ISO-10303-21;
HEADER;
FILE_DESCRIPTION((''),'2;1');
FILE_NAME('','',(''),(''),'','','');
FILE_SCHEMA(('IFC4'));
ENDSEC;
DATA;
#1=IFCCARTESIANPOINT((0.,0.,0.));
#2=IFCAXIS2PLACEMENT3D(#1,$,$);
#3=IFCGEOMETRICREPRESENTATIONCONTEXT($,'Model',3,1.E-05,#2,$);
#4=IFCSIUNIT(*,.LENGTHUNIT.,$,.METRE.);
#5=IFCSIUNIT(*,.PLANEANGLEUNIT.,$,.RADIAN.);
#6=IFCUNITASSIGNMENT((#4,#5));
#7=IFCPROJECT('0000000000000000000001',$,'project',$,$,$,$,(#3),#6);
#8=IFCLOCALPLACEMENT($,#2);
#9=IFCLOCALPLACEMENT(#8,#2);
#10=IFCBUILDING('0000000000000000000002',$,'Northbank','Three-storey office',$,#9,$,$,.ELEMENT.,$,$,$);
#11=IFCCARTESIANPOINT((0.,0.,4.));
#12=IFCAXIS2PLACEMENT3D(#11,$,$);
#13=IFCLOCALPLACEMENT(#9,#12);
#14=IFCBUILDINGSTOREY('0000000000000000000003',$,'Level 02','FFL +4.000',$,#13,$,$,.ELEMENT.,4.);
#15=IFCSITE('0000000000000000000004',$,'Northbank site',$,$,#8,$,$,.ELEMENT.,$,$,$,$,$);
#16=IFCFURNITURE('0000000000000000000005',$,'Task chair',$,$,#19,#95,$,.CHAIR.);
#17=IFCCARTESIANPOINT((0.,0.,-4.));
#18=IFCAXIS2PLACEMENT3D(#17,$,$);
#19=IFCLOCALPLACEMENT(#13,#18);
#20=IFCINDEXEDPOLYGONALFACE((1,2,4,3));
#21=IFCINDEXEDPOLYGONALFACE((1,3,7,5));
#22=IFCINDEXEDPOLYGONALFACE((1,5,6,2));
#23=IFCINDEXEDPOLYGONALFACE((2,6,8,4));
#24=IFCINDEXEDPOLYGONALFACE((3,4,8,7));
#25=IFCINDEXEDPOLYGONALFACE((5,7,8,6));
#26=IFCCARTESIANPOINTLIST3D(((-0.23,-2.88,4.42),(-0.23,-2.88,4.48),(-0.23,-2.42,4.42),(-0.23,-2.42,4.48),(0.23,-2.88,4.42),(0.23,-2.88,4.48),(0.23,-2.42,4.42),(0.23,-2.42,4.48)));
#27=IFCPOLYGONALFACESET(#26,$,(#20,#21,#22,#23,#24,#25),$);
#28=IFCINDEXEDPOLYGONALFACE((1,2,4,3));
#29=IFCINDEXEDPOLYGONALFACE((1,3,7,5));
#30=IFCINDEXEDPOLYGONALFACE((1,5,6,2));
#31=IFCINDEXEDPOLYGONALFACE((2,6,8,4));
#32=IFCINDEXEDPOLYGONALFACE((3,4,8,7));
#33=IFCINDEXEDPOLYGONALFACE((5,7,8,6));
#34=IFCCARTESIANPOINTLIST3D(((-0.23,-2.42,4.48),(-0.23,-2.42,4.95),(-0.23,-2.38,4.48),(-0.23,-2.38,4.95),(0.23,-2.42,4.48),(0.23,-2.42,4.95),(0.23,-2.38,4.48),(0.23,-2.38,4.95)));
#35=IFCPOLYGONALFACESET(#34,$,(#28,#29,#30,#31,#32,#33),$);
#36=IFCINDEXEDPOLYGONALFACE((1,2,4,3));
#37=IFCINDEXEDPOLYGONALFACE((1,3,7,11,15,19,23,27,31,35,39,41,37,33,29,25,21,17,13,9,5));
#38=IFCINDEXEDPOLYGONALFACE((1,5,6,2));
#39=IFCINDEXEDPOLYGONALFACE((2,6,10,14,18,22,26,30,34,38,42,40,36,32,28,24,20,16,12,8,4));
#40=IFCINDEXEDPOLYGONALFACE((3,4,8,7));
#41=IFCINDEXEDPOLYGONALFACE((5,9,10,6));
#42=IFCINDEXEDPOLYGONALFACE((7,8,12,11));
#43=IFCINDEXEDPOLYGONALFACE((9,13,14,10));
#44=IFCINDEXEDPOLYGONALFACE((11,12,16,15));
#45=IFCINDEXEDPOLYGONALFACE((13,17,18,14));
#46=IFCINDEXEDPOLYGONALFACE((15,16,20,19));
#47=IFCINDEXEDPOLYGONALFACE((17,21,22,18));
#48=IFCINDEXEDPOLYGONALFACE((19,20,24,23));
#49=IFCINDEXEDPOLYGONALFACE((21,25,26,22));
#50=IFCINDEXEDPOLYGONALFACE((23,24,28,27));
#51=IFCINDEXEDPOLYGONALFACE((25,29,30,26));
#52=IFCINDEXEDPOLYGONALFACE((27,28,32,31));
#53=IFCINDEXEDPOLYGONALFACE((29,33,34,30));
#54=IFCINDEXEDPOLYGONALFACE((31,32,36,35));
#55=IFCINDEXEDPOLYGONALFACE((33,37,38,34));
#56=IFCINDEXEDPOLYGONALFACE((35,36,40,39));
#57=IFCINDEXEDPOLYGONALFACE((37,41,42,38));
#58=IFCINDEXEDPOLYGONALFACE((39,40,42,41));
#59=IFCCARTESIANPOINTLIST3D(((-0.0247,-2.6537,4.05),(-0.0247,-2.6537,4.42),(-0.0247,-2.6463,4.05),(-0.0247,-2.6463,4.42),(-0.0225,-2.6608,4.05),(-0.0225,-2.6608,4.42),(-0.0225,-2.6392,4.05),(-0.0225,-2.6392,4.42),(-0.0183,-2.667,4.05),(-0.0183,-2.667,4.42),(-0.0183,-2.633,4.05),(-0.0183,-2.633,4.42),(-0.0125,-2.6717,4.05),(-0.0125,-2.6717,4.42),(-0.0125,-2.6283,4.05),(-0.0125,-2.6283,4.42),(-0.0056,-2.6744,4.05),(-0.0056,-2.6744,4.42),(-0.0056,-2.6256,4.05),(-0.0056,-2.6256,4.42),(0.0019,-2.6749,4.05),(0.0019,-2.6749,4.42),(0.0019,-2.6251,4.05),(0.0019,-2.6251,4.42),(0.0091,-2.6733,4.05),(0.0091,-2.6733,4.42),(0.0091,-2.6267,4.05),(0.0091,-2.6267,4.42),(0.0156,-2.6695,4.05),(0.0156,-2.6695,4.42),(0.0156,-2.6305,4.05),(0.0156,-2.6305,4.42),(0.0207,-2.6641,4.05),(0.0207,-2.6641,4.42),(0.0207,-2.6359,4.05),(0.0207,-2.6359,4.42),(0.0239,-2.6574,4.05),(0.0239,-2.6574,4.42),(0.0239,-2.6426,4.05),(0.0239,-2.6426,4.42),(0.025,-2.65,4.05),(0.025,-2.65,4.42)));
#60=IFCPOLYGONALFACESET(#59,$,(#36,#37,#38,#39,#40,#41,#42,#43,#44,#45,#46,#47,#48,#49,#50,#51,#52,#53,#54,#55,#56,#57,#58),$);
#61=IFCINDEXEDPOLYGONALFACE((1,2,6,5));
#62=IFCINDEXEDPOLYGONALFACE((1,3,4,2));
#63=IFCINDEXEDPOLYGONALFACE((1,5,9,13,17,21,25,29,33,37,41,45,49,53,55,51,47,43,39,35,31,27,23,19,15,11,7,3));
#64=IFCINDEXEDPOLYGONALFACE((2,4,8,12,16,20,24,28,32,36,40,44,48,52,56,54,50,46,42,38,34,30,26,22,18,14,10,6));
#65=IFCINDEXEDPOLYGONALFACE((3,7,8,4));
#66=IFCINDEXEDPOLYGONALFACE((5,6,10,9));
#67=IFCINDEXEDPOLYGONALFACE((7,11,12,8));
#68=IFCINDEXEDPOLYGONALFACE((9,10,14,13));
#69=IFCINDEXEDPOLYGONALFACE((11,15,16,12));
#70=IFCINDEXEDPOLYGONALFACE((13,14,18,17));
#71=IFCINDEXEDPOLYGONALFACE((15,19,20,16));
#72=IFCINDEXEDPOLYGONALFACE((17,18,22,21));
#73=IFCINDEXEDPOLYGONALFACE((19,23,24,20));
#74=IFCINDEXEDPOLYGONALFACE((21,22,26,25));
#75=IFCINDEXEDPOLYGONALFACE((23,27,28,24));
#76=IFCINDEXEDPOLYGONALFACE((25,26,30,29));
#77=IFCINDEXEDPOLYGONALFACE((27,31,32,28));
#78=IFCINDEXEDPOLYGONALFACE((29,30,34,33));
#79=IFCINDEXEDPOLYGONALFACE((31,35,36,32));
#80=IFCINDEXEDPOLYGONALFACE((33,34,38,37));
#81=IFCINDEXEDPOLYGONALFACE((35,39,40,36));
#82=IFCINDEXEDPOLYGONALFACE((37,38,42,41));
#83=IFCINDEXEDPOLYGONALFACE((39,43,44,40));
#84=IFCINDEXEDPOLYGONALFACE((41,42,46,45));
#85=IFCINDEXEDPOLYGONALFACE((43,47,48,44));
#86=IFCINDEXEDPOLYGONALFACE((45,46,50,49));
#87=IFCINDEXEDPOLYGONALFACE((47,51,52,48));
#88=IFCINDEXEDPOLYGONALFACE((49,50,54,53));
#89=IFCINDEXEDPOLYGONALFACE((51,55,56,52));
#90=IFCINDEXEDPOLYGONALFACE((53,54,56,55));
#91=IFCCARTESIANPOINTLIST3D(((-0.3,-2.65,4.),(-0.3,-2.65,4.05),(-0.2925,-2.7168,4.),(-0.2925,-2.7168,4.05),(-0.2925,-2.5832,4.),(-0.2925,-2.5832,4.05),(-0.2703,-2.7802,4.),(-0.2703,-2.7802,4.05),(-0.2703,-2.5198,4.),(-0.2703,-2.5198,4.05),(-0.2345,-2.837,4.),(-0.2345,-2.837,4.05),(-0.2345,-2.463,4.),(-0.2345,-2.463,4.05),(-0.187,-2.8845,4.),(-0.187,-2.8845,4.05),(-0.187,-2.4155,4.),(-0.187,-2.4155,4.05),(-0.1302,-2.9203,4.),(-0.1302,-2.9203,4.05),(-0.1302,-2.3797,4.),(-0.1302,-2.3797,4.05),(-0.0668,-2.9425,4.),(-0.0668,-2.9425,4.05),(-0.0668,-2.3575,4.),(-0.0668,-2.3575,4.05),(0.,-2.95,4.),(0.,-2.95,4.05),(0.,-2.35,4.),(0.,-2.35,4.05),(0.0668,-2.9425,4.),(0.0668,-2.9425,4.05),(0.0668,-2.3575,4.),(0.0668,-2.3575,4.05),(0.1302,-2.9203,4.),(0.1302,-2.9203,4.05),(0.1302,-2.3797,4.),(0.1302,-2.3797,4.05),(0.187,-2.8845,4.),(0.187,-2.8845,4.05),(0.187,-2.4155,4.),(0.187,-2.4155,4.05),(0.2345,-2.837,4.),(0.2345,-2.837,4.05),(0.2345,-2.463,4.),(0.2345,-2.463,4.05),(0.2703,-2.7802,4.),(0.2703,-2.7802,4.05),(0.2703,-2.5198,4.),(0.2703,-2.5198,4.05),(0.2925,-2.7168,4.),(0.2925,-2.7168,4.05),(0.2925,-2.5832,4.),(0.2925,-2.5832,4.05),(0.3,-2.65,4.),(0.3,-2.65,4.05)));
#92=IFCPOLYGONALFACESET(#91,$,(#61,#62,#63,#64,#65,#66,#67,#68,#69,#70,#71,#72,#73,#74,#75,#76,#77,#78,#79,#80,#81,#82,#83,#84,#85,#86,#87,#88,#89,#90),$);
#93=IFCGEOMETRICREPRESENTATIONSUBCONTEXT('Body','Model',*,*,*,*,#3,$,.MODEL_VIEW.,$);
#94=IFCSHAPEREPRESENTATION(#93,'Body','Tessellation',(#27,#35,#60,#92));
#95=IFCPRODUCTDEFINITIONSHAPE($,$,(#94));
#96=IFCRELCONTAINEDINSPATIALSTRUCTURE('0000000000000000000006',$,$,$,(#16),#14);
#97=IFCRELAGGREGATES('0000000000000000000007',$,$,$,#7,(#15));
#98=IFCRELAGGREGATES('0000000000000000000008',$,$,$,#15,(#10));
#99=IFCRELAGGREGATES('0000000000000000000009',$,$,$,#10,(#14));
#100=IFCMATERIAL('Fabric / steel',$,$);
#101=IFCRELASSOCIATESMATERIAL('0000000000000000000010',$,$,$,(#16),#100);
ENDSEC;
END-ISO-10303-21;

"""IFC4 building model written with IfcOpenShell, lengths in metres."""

from ifc_helpers import new_model, si_unit, frame, origin, place, context, subcontext, project, spatial, rectangle, circle, extrude, material, element, save


model = new_model("IFC4")

# Units and contexts
model_context = context("Model", 3, precision=1e-05, world=origin())
body_context = subcontext(model_context, "Body", "Model", "MODEL_VIEW")
ifc_project = project(units=[si_unit("LENGTHUNIT", "METRE"), si_unit("PLANEANGLEUNIT", "RADIAN")], contexts=[model_context])

# Site, building, storey
site_placement = place(None, origin())
site = spatial("IfcSite", under=ifc_project, at=site_placement, Name="Northbank site", CompositionType="ELEMENT")
building_placement = place(site_placement, origin())
building = spatial("IfcBuilding", under=site, at=building_placement, Name="Northbank", Description="Three-storey office", CompositionType="ELEMENT")
storey_placement = place(building_placement, frame((0.0, 0.0, 4.0)))
storey = spatial("IfcBuildingStorey", under=building, at=storey_placement, Name="Level 02", Description="FFL +4.000", CompositionType="ELEMENT", Elevation=4.0)

# Furniture
ifc_material_1 = material(Name="Fabric / steel")
furniture_1_placement = place(storey_placement, frame((0.0, 0.0, -4.0)))
element("IfcFurniture", 1, at=furniture_1_placement, inside=storey, material=ifc_material_1, Name="Task chair", PredefinedType="CHAIR", context=body_context, shape_type="SweptSolid", body=[
    extrude(rectangle(XDim=0.46, YDim=0.46), frame((0.0, -2.65, 4.42)), (0.0, 0.0, 1.0), 0.06),
    extrude(rectangle(XDim=0.46, YDim=0.04), frame((0.0, -2.4, 4.48)), (0.0, 0.0, 1.0), 0.47),
    extrude(circle(Radius=0.025), frame((0.0, -2.65, 4.05), z_axis=(0.0, 0.0, 1.0), x_axis=(1.0, 0.0, 0.0)), (0.0, 0.0, 1.0), 0.37),
    extrude(circle(Radius=0.3), frame((0.0, -2.65, 4.0), z_axis=(0.0, 0.0, 1.0), x_axis=(1.0, 0.0, 0.0)), (0.0, 0.0, 1.0), 0.05),
])

save(model, "model.ifc")
